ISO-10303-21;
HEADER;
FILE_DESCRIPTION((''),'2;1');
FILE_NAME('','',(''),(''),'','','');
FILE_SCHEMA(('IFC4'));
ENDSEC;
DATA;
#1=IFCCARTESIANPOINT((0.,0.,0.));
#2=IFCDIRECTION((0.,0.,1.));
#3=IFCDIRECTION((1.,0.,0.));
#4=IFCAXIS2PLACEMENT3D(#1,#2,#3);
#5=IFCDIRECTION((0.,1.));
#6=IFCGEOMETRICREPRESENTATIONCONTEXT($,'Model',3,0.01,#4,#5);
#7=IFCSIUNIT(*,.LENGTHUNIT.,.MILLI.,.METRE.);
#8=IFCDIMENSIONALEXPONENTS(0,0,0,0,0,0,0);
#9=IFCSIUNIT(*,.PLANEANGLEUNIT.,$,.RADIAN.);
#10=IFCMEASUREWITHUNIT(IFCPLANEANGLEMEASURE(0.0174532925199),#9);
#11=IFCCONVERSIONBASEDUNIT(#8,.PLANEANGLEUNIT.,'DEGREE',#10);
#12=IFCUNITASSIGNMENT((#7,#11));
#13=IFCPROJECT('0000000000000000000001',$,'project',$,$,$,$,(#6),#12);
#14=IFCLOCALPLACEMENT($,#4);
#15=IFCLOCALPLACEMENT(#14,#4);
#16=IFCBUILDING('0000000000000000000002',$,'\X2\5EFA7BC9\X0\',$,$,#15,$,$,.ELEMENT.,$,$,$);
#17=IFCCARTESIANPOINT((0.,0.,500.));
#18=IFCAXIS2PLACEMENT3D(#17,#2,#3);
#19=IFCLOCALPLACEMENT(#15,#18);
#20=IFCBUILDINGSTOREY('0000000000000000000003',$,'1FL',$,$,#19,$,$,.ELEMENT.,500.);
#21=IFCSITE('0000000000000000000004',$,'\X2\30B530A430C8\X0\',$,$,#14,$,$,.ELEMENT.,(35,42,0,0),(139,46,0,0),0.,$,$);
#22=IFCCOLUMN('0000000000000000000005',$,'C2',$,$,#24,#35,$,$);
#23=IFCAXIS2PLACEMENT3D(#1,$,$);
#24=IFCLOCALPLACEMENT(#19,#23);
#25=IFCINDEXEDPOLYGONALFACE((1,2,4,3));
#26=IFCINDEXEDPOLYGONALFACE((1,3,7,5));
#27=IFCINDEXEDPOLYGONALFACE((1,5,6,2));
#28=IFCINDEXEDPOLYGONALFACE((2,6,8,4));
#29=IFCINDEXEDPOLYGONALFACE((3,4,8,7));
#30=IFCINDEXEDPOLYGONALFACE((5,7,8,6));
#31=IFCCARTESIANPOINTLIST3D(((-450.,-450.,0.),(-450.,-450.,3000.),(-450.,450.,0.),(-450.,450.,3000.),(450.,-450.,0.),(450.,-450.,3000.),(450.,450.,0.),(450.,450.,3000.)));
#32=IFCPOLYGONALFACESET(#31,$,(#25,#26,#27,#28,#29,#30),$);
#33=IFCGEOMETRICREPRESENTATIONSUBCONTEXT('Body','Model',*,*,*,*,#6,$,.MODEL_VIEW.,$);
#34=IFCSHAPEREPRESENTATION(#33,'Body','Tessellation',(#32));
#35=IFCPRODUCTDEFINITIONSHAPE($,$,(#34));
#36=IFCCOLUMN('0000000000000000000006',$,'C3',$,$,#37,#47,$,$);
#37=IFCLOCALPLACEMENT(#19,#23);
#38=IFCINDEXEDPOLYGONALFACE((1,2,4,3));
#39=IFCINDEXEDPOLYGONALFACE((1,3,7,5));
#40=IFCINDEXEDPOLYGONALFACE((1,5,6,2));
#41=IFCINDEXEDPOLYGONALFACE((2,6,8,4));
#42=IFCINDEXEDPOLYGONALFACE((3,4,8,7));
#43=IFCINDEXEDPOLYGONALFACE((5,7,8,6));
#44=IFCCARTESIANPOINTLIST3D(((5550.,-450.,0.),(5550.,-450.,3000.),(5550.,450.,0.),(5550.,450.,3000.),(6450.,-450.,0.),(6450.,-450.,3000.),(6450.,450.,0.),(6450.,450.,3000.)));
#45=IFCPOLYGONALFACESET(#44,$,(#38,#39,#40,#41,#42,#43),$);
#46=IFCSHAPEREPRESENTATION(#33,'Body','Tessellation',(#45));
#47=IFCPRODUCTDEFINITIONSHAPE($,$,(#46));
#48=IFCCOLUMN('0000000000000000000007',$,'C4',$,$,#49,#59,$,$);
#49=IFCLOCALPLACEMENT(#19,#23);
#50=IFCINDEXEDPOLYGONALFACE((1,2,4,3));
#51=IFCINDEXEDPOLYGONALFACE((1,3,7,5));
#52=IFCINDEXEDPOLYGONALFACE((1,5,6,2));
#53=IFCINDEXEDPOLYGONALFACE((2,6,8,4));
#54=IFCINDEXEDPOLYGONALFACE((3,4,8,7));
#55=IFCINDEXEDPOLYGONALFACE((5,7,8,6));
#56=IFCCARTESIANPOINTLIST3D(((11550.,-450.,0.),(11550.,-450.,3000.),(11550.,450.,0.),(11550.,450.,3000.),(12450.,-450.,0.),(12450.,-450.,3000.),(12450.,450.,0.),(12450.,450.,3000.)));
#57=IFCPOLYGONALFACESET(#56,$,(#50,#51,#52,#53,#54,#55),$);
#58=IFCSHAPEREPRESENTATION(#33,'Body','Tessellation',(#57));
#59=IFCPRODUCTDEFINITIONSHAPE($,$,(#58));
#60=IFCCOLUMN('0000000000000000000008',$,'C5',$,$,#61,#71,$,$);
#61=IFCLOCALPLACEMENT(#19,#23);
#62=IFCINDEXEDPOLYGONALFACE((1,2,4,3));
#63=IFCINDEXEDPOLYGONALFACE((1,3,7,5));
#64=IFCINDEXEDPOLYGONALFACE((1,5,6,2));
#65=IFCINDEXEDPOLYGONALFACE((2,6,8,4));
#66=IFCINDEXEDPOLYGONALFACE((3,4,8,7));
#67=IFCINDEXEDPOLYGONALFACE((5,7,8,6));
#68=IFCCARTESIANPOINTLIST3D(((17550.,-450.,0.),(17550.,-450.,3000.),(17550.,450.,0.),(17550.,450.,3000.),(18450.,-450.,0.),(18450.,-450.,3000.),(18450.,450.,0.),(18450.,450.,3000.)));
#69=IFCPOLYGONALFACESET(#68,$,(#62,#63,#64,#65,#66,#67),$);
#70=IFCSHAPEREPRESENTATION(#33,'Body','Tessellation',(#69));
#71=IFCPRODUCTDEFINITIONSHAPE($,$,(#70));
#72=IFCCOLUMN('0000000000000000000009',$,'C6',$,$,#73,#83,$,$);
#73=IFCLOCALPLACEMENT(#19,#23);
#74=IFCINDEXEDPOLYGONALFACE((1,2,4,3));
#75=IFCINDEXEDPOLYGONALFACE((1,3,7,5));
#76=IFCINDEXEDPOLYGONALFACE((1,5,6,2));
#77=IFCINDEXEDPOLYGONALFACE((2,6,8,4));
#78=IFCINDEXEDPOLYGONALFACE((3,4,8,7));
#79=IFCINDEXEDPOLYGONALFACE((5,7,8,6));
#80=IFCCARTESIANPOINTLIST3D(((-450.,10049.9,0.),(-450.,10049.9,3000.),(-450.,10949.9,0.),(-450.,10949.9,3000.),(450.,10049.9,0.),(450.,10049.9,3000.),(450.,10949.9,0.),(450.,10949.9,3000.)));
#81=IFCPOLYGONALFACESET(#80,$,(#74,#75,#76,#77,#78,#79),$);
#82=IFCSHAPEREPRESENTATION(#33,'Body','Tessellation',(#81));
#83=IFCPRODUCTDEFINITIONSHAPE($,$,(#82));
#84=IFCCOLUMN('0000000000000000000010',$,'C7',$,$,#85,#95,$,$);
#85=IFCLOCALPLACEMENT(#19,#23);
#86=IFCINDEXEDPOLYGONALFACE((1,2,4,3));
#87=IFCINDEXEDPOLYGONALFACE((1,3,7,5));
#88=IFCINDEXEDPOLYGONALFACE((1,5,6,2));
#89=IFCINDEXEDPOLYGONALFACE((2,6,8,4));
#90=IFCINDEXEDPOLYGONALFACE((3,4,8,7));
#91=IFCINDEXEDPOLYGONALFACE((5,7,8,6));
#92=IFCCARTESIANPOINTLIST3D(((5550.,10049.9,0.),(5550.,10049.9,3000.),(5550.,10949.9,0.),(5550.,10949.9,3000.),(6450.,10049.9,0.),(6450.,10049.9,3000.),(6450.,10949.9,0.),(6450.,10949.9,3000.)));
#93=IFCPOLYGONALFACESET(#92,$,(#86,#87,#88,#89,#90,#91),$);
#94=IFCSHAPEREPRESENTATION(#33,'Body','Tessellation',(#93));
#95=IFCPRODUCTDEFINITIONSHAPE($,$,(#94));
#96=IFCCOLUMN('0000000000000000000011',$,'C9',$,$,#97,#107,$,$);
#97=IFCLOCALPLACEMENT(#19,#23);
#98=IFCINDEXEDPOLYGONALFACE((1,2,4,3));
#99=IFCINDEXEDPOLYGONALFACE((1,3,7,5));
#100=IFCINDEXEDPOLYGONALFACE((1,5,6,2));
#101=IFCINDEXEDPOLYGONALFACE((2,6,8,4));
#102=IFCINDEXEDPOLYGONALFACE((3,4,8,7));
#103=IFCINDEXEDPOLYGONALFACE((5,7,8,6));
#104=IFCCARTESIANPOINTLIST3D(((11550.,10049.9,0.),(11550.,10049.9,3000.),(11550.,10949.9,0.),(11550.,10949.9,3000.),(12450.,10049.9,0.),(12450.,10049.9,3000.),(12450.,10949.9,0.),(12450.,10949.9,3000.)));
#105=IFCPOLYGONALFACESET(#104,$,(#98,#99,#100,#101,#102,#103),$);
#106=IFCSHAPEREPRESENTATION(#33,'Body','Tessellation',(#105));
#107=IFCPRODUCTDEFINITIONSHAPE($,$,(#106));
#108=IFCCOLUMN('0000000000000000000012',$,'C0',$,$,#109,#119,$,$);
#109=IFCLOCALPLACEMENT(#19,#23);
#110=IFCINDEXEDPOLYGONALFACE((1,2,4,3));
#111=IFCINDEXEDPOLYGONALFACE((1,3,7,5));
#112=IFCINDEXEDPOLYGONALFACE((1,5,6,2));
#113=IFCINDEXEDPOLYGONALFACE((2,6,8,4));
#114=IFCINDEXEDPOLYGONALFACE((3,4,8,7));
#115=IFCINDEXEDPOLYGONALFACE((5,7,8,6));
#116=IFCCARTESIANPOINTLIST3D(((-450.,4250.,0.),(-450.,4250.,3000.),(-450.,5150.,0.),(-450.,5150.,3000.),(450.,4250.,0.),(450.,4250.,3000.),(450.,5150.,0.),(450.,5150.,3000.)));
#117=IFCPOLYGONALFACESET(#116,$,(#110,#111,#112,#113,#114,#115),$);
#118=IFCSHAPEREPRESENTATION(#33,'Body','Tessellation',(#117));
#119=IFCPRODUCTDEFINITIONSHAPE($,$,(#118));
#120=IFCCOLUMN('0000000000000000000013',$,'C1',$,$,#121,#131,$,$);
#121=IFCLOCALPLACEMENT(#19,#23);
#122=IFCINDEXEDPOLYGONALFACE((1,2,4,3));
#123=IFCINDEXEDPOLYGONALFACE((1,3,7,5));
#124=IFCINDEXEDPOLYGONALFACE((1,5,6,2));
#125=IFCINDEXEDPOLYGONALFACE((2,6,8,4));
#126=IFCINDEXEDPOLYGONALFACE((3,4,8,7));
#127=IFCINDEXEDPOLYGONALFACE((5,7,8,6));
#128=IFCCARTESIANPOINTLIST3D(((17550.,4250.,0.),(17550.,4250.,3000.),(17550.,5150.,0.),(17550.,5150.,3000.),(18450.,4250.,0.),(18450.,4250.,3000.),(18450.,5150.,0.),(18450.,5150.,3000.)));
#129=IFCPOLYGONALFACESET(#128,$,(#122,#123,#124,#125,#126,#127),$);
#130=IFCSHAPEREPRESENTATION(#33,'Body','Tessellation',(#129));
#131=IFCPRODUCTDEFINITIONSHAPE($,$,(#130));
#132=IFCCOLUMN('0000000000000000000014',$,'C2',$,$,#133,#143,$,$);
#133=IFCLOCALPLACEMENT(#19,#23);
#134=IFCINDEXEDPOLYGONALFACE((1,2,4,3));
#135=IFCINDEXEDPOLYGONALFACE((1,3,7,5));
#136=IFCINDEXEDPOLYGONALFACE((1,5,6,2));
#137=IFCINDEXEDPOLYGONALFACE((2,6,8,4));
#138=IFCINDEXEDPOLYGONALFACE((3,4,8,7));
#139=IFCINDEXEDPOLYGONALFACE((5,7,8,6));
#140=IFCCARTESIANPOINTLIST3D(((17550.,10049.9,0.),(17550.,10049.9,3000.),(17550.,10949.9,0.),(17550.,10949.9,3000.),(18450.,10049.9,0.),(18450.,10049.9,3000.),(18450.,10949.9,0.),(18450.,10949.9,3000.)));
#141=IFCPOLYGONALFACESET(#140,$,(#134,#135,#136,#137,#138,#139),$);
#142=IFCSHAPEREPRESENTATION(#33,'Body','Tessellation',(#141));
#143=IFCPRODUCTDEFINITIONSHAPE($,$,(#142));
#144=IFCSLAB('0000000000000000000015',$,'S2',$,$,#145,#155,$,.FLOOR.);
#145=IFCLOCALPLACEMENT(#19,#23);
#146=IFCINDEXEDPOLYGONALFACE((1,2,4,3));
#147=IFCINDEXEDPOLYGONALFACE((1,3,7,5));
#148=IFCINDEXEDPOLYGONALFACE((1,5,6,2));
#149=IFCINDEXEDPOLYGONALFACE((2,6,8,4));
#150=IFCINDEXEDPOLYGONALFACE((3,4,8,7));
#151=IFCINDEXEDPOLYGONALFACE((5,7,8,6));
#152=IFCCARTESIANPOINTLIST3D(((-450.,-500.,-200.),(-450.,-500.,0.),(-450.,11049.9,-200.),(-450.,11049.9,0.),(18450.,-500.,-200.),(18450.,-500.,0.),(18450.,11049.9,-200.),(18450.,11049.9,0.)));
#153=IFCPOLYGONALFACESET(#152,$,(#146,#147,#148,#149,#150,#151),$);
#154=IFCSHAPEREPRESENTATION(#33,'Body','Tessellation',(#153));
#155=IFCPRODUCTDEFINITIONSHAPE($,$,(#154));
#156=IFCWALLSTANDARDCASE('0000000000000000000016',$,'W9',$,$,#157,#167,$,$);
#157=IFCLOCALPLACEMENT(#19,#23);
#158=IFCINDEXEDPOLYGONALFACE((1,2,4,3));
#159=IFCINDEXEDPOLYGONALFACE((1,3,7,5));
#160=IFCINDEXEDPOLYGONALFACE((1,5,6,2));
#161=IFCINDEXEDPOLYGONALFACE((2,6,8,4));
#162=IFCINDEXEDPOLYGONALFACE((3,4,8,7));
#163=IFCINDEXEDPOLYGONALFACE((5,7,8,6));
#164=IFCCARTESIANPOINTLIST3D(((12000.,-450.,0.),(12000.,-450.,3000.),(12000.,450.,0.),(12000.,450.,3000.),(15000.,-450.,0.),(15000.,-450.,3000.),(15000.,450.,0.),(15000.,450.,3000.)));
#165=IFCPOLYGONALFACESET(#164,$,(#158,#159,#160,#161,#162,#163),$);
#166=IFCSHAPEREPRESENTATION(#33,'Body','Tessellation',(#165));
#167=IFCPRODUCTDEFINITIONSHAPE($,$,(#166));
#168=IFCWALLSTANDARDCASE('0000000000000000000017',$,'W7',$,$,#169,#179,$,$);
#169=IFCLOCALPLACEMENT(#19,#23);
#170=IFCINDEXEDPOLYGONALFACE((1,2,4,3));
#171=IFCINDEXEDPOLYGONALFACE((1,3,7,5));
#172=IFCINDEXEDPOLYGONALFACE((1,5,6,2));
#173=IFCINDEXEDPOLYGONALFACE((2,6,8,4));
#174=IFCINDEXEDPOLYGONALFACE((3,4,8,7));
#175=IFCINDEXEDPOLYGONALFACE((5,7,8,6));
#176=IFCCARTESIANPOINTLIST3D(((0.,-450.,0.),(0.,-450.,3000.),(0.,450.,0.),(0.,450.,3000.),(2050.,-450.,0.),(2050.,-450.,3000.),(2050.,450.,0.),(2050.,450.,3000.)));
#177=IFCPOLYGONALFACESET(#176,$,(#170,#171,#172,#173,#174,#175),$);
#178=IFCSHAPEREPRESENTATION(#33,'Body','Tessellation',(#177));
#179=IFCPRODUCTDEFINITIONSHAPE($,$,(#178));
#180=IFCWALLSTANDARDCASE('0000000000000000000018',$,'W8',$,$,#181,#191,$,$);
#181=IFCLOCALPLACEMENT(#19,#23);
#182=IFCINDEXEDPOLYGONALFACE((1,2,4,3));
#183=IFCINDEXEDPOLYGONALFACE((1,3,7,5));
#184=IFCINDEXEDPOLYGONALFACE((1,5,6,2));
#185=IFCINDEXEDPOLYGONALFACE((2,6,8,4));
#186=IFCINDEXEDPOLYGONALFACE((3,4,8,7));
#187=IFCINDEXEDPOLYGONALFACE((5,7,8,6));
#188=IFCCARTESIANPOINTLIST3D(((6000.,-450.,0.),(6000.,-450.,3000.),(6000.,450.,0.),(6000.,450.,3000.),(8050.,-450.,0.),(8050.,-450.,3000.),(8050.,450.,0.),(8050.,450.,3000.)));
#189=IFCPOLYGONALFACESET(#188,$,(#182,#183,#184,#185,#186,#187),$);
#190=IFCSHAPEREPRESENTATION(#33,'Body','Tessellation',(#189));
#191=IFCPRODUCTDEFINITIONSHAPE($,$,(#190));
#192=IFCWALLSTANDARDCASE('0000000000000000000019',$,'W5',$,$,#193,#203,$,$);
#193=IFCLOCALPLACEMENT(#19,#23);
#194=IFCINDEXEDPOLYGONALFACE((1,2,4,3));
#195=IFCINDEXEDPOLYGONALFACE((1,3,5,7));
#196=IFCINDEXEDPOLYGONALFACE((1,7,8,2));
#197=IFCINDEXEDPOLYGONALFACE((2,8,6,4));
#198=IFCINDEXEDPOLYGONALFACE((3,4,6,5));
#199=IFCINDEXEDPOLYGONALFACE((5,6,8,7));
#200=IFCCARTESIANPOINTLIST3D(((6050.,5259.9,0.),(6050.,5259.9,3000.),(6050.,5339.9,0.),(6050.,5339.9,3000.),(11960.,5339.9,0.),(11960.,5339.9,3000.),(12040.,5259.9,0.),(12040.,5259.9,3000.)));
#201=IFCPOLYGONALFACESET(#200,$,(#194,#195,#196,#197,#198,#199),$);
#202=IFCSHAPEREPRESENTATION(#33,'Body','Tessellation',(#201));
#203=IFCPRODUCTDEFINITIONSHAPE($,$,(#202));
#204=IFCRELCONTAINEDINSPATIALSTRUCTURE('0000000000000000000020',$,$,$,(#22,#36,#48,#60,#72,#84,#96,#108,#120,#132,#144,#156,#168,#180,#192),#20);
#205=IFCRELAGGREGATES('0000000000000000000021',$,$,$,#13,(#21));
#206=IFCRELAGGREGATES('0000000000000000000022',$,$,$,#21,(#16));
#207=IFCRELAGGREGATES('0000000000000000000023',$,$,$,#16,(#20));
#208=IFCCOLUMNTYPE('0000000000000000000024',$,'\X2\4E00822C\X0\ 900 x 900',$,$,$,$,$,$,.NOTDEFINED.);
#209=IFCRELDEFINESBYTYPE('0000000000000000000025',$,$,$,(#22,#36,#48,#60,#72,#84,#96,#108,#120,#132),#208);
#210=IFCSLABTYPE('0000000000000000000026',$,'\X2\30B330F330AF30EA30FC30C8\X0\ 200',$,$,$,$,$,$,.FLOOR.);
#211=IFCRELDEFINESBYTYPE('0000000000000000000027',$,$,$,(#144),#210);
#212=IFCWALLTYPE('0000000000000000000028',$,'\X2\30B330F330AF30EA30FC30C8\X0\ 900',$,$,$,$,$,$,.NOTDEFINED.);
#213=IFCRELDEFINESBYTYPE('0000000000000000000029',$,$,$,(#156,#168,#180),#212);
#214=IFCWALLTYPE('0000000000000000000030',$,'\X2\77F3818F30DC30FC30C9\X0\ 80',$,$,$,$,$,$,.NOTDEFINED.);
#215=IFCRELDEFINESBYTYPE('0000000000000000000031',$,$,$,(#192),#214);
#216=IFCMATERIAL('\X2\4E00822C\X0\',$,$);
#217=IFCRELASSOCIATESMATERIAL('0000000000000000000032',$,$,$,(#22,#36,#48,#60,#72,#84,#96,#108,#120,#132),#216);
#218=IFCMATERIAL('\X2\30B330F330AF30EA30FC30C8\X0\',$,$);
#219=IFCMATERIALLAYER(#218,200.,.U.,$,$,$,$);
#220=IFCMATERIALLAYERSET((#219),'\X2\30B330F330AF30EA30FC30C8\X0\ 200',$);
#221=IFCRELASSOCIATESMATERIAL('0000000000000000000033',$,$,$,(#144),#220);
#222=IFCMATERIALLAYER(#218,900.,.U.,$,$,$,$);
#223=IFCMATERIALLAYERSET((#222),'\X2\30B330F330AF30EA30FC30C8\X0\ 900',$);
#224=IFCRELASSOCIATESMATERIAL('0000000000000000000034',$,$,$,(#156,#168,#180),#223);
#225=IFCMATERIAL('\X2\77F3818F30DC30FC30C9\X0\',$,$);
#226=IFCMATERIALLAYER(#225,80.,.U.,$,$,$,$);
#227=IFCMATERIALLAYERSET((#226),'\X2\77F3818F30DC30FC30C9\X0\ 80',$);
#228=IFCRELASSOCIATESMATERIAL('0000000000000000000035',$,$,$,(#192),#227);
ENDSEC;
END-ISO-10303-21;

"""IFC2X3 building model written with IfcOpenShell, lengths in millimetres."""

from ifc_helpers import new_model, entity, si_unit, converted_unit, direction, frame, origin_with_axes, origin_2d_with_axis, place, context, subcontext, project, spatial, polyline, rectangle, outline, extrude, material, layer, layer_set, layer_usage, type_object, element, save


model = new_model("IFC2X3")

# Units and contexts
model_context = context("Model", 3, precision=0.01, world=origin_with_axes(), true_north=direction((0.0, 1.0)))
body_context = subcontext(model_context, "Body", "Model", "MODEL_VIEW")
ifc_project = project(units=[si_unit("LENGTHUNIT", "METRE", prefix="MILLI"), converted_unit("PLANEANGLEUNIT", "DEGREE", entity("IfcPlaneAngleMeasure", 0.0174532925199), si_unit("PLANEANGLEUNIT", "RADIAN"), dimensions=[0, 0, 0, 0, 0, 0, 0])], contexts=[model_context])

# Site, building, storey
site_placement = place(None, origin_with_axes())
site = spatial("IfcSite", under=ifc_project, at=site_placement, Name="サイト", CompositionType="ELEMENT", RefLatitude=(35, 42, 0, 0), RefLongitude=(139, 46, 0, 0), RefElevation=0.0)
building_placement = place(site_placement, origin_with_axes())
building = spatial("IfcBuilding", under=site, at=building_placement, Name="建築", CompositionType="ELEMENT")
storey_placement = place(building_placement, frame((0.0, 0.0, 500.0), z_axis=(0.0, 0.0, 1.0), x_axis=(1.0, 0.0, 0.0)))
storey = spatial("IfcBuildingStorey", under=building, at=storey_placement, Name="1FL", CompositionType="ELEMENT", Elevation=500.0)

# Columns
ifc_material_1 = material(Name="一般")
column_type = type_object("IfcColumnType", Name="一般 900 x 900", PredefinedType="NOTDEFINED")
for number, where, z_axis, x_axis, name in (
    (1, (0.0, 0.0, 0.0), (0.0, 0.0, 1.0), (1.0, 0.0, 0.0), "C2"),
    (2, (6000.0, 0.0, 0.0), (0.0, 0.0, 1.0), (1.0, 0.0, 0.0), "C3"),
    (3, (12000.0, 0.0, 0.0), (0.0, 0.0, 1.0), (1.0, 0.0, 0.0), "C4"),
    (4, (18000.0, 0.0, 0.0), (0.0, 0.0, 1.0), (1.0, 0.0, 0.0), "C5"),
    (5, (0.0, 10499.9, 0.0), (0.0, 0.0, 1.0), (1.0, 0.0, 0.0), "C6"),
    (6, (6000.0, 10499.9, 0.0), (0.0, 0.0, 1.0), (1.0, 0.0, 0.0), "C7"),
    (7, (12000.0, 10499.9, 0.0), (0.0, 0.0, 1.0), (1.0, 0.0, 0.0), "C9"),
    (8, (0.0, 4700.0, 0.0), (0.0, 0.0, 1.0), (1.0, 0.0, 0.0), "C0"),
    (9, (18000.0, 4700.0, 0.0), (0.0, 0.0, 1.0), (1.0, 0.0, 0.0), "C1"),
    (10, (18000.0, 10499.9, 0.0), (0.0, 0.0, 1.0), (1.0, 0.0, 0.0), "C2"),
):
    element("IfcColumn", number, at=place(storey_placement, frame(where, z_axis=z_axis, x_axis=x_axis)), inside=storey, type_object=column_type, material=ifc_material_1, Name=name, context=body_context, shape_type="SweptSolid", body=[
        extrude(rectangle(XDim=900.0, YDim=900.0, at=origin_2d_with_axis()), origin_with_axes(), (0.0, 0.0, 1.0), 3000.0),
    ])

# Slab
ifc_material_2 = material(Name="コンクリート")
ifc_layer_1 = layer(ifc_material_2, 200.0, ventilated="UNKNOWN")
ifc_layer_set_1 = layer_set([ifc_layer_1], Name="コンクリート 200")
ifc_layer_usage_1 = layer_usage(ifc_layer_set_1, "AXIS3", "NEGATIVE", 200.0)
slab_type = type_object("IfcSlabType", Name="コンクリート 200", PredefinedType="FLOOR")
slab_placement = place(storey_placement, frame((-450.0, -500.0, 0.0), z_axis=(0.0, 0.0, 1.0), x_axis=(1.0, 0.0, 0.0)))
element("IfcSlab", 11, at=slab_placement, inside=storey, type_object=slab_type, material=ifc_layer_usage_1, Name="S2", PredefinedType="FLOOR", context=body_context, shape_type="SweptSolid", body=[
    extrude(outline(polyline([(0.0, 0.0), (18900.0, 0.0), (18900.0, 11549.9), (0.0, 11549.9), (0.0, 0.0)])), frame((0.0, 0.0, -200.0), z_axis=(0.0, 0.0, 1.0), x_axis=(1.0, 0.0, 0.0)), (0.0, 0.0, 1.0), 200.0),
])

# Walls
ifc_layer_2 = layer(ifc_material_2, 900.0, ventilated="UNKNOWN")
ifc_layer_set_2 = layer_set([ifc_layer_2], Name="コンクリート 900")
ifc_layer_usage_2 = layer_usage(ifc_layer_set_2, "AXIS2", "POSITIVE", -450.0)
wall_type_1 = type_object("IfcWallType", Name="コンクリート 900", PredefinedType="NOTDEFINED")
wall_1_placement = place(storey_placement, frame((12000.0, 0.0, 0.0), z_axis=(0.0, 0.0, 1.0), x_axis=(1.0, 0.0, 0.0)))
element("IfcWallStandardCase", 12, at=wall_1_placement, inside=storey, type_object=wall_type_1, material=ifc_layer_usage_2, Name="W9", context=body_context, shape_type="SweptSolid", body=[
    extrude(outline(polyline([(0.0, -450.0), (3000.0, -450.0), (3000.0, 450.0), (0.0, 450.0), (0.0, -450.0)])), origin_with_axes(), (0.0, 0.0, 1.0), 3000.0),
])
ifc_layer_usage_3 = layer_usage(ifc_layer_set_2, "AXIS2", "POSITIVE", -450.0)
wall_2_placement = place(storey_placement, origin_with_axes())
element("IfcWallStandardCase", 13, at=wall_2_placement, inside=storey, type_object=wall_type_1, material=ifc_layer_usage_3, Name="W7", context=body_context, shape_type="SweptSolid", body=[
    extrude(outline(polyline([(0.0, -450.0), (2050.0, -450.0), (2050.0, 450.0), (0.0, 450.0), (0.0, -450.0)])), origin_with_axes(), (0.0, 0.0, 1.0), 3000.0),
])
ifc_layer_usage_4 = layer_usage(ifc_layer_set_2, "AXIS2", "POSITIVE", -450.0)
wall_3_placement = place(storey_placement, frame((6000.0, 0.0, 0.0), z_axis=(0.0, 0.0, 1.0), x_axis=(1.0, 0.0, 0.0)))
element("IfcWallStandardCase", 14, at=wall_3_placement, inside=storey, type_object=wall_type_1, material=ifc_layer_usage_4, Name="W8", context=body_context, shape_type="SweptSolid", body=[
    extrude(outline(polyline([(0.0, -450.0), (2050.0, -450.0), (2050.0, 450.0), (0.0, 450.0), (0.0, -450.0)])), origin_with_axes(), (0.0, 0.0, 1.0), 3000.0),
])

# Shared definitions
ifc_material_3 = material(Name="石膏ボード")

# Wall
ifc_layer_3 = layer(ifc_material_3, 80.0, ventilated="UNKNOWN")
ifc_layer_set_3 = layer_set([ifc_layer_3], Name="石膏ボード 80")
wall_type_2 = type_object("IfcWallType", Name="石膏ボード 80", PredefinedType="NOTDEFINED")
ifc_layer_usage_5 = layer_usage(ifc_layer_set_3, "AXIS2", "POSITIVE", -40.0)
wall_4_placement = place(storey_placement, frame((12000.0, 5299.9, 0.0), z_axis=(0.0, 0.0, 1.0), x_axis=(-1.0, 0.0, 0.0)))
element("IfcWallStandardCase", 15, at=wall_4_placement, inside=storey, type_object=wall_type_2, material=ifc_layer_usage_5, Name="W5", context=body_context, shape_type="SweptSolid", body=[
    extrude(outline(polyline([(40.0, -40.0), (5950.0, -40.0), (5950.0, 40.0), (-40.0, 40.0), (40.0, -40.0)])), origin_with_axes(), (0.0, 0.0, 1.0), 3000.0),
])

save(model, "model.ifc")
